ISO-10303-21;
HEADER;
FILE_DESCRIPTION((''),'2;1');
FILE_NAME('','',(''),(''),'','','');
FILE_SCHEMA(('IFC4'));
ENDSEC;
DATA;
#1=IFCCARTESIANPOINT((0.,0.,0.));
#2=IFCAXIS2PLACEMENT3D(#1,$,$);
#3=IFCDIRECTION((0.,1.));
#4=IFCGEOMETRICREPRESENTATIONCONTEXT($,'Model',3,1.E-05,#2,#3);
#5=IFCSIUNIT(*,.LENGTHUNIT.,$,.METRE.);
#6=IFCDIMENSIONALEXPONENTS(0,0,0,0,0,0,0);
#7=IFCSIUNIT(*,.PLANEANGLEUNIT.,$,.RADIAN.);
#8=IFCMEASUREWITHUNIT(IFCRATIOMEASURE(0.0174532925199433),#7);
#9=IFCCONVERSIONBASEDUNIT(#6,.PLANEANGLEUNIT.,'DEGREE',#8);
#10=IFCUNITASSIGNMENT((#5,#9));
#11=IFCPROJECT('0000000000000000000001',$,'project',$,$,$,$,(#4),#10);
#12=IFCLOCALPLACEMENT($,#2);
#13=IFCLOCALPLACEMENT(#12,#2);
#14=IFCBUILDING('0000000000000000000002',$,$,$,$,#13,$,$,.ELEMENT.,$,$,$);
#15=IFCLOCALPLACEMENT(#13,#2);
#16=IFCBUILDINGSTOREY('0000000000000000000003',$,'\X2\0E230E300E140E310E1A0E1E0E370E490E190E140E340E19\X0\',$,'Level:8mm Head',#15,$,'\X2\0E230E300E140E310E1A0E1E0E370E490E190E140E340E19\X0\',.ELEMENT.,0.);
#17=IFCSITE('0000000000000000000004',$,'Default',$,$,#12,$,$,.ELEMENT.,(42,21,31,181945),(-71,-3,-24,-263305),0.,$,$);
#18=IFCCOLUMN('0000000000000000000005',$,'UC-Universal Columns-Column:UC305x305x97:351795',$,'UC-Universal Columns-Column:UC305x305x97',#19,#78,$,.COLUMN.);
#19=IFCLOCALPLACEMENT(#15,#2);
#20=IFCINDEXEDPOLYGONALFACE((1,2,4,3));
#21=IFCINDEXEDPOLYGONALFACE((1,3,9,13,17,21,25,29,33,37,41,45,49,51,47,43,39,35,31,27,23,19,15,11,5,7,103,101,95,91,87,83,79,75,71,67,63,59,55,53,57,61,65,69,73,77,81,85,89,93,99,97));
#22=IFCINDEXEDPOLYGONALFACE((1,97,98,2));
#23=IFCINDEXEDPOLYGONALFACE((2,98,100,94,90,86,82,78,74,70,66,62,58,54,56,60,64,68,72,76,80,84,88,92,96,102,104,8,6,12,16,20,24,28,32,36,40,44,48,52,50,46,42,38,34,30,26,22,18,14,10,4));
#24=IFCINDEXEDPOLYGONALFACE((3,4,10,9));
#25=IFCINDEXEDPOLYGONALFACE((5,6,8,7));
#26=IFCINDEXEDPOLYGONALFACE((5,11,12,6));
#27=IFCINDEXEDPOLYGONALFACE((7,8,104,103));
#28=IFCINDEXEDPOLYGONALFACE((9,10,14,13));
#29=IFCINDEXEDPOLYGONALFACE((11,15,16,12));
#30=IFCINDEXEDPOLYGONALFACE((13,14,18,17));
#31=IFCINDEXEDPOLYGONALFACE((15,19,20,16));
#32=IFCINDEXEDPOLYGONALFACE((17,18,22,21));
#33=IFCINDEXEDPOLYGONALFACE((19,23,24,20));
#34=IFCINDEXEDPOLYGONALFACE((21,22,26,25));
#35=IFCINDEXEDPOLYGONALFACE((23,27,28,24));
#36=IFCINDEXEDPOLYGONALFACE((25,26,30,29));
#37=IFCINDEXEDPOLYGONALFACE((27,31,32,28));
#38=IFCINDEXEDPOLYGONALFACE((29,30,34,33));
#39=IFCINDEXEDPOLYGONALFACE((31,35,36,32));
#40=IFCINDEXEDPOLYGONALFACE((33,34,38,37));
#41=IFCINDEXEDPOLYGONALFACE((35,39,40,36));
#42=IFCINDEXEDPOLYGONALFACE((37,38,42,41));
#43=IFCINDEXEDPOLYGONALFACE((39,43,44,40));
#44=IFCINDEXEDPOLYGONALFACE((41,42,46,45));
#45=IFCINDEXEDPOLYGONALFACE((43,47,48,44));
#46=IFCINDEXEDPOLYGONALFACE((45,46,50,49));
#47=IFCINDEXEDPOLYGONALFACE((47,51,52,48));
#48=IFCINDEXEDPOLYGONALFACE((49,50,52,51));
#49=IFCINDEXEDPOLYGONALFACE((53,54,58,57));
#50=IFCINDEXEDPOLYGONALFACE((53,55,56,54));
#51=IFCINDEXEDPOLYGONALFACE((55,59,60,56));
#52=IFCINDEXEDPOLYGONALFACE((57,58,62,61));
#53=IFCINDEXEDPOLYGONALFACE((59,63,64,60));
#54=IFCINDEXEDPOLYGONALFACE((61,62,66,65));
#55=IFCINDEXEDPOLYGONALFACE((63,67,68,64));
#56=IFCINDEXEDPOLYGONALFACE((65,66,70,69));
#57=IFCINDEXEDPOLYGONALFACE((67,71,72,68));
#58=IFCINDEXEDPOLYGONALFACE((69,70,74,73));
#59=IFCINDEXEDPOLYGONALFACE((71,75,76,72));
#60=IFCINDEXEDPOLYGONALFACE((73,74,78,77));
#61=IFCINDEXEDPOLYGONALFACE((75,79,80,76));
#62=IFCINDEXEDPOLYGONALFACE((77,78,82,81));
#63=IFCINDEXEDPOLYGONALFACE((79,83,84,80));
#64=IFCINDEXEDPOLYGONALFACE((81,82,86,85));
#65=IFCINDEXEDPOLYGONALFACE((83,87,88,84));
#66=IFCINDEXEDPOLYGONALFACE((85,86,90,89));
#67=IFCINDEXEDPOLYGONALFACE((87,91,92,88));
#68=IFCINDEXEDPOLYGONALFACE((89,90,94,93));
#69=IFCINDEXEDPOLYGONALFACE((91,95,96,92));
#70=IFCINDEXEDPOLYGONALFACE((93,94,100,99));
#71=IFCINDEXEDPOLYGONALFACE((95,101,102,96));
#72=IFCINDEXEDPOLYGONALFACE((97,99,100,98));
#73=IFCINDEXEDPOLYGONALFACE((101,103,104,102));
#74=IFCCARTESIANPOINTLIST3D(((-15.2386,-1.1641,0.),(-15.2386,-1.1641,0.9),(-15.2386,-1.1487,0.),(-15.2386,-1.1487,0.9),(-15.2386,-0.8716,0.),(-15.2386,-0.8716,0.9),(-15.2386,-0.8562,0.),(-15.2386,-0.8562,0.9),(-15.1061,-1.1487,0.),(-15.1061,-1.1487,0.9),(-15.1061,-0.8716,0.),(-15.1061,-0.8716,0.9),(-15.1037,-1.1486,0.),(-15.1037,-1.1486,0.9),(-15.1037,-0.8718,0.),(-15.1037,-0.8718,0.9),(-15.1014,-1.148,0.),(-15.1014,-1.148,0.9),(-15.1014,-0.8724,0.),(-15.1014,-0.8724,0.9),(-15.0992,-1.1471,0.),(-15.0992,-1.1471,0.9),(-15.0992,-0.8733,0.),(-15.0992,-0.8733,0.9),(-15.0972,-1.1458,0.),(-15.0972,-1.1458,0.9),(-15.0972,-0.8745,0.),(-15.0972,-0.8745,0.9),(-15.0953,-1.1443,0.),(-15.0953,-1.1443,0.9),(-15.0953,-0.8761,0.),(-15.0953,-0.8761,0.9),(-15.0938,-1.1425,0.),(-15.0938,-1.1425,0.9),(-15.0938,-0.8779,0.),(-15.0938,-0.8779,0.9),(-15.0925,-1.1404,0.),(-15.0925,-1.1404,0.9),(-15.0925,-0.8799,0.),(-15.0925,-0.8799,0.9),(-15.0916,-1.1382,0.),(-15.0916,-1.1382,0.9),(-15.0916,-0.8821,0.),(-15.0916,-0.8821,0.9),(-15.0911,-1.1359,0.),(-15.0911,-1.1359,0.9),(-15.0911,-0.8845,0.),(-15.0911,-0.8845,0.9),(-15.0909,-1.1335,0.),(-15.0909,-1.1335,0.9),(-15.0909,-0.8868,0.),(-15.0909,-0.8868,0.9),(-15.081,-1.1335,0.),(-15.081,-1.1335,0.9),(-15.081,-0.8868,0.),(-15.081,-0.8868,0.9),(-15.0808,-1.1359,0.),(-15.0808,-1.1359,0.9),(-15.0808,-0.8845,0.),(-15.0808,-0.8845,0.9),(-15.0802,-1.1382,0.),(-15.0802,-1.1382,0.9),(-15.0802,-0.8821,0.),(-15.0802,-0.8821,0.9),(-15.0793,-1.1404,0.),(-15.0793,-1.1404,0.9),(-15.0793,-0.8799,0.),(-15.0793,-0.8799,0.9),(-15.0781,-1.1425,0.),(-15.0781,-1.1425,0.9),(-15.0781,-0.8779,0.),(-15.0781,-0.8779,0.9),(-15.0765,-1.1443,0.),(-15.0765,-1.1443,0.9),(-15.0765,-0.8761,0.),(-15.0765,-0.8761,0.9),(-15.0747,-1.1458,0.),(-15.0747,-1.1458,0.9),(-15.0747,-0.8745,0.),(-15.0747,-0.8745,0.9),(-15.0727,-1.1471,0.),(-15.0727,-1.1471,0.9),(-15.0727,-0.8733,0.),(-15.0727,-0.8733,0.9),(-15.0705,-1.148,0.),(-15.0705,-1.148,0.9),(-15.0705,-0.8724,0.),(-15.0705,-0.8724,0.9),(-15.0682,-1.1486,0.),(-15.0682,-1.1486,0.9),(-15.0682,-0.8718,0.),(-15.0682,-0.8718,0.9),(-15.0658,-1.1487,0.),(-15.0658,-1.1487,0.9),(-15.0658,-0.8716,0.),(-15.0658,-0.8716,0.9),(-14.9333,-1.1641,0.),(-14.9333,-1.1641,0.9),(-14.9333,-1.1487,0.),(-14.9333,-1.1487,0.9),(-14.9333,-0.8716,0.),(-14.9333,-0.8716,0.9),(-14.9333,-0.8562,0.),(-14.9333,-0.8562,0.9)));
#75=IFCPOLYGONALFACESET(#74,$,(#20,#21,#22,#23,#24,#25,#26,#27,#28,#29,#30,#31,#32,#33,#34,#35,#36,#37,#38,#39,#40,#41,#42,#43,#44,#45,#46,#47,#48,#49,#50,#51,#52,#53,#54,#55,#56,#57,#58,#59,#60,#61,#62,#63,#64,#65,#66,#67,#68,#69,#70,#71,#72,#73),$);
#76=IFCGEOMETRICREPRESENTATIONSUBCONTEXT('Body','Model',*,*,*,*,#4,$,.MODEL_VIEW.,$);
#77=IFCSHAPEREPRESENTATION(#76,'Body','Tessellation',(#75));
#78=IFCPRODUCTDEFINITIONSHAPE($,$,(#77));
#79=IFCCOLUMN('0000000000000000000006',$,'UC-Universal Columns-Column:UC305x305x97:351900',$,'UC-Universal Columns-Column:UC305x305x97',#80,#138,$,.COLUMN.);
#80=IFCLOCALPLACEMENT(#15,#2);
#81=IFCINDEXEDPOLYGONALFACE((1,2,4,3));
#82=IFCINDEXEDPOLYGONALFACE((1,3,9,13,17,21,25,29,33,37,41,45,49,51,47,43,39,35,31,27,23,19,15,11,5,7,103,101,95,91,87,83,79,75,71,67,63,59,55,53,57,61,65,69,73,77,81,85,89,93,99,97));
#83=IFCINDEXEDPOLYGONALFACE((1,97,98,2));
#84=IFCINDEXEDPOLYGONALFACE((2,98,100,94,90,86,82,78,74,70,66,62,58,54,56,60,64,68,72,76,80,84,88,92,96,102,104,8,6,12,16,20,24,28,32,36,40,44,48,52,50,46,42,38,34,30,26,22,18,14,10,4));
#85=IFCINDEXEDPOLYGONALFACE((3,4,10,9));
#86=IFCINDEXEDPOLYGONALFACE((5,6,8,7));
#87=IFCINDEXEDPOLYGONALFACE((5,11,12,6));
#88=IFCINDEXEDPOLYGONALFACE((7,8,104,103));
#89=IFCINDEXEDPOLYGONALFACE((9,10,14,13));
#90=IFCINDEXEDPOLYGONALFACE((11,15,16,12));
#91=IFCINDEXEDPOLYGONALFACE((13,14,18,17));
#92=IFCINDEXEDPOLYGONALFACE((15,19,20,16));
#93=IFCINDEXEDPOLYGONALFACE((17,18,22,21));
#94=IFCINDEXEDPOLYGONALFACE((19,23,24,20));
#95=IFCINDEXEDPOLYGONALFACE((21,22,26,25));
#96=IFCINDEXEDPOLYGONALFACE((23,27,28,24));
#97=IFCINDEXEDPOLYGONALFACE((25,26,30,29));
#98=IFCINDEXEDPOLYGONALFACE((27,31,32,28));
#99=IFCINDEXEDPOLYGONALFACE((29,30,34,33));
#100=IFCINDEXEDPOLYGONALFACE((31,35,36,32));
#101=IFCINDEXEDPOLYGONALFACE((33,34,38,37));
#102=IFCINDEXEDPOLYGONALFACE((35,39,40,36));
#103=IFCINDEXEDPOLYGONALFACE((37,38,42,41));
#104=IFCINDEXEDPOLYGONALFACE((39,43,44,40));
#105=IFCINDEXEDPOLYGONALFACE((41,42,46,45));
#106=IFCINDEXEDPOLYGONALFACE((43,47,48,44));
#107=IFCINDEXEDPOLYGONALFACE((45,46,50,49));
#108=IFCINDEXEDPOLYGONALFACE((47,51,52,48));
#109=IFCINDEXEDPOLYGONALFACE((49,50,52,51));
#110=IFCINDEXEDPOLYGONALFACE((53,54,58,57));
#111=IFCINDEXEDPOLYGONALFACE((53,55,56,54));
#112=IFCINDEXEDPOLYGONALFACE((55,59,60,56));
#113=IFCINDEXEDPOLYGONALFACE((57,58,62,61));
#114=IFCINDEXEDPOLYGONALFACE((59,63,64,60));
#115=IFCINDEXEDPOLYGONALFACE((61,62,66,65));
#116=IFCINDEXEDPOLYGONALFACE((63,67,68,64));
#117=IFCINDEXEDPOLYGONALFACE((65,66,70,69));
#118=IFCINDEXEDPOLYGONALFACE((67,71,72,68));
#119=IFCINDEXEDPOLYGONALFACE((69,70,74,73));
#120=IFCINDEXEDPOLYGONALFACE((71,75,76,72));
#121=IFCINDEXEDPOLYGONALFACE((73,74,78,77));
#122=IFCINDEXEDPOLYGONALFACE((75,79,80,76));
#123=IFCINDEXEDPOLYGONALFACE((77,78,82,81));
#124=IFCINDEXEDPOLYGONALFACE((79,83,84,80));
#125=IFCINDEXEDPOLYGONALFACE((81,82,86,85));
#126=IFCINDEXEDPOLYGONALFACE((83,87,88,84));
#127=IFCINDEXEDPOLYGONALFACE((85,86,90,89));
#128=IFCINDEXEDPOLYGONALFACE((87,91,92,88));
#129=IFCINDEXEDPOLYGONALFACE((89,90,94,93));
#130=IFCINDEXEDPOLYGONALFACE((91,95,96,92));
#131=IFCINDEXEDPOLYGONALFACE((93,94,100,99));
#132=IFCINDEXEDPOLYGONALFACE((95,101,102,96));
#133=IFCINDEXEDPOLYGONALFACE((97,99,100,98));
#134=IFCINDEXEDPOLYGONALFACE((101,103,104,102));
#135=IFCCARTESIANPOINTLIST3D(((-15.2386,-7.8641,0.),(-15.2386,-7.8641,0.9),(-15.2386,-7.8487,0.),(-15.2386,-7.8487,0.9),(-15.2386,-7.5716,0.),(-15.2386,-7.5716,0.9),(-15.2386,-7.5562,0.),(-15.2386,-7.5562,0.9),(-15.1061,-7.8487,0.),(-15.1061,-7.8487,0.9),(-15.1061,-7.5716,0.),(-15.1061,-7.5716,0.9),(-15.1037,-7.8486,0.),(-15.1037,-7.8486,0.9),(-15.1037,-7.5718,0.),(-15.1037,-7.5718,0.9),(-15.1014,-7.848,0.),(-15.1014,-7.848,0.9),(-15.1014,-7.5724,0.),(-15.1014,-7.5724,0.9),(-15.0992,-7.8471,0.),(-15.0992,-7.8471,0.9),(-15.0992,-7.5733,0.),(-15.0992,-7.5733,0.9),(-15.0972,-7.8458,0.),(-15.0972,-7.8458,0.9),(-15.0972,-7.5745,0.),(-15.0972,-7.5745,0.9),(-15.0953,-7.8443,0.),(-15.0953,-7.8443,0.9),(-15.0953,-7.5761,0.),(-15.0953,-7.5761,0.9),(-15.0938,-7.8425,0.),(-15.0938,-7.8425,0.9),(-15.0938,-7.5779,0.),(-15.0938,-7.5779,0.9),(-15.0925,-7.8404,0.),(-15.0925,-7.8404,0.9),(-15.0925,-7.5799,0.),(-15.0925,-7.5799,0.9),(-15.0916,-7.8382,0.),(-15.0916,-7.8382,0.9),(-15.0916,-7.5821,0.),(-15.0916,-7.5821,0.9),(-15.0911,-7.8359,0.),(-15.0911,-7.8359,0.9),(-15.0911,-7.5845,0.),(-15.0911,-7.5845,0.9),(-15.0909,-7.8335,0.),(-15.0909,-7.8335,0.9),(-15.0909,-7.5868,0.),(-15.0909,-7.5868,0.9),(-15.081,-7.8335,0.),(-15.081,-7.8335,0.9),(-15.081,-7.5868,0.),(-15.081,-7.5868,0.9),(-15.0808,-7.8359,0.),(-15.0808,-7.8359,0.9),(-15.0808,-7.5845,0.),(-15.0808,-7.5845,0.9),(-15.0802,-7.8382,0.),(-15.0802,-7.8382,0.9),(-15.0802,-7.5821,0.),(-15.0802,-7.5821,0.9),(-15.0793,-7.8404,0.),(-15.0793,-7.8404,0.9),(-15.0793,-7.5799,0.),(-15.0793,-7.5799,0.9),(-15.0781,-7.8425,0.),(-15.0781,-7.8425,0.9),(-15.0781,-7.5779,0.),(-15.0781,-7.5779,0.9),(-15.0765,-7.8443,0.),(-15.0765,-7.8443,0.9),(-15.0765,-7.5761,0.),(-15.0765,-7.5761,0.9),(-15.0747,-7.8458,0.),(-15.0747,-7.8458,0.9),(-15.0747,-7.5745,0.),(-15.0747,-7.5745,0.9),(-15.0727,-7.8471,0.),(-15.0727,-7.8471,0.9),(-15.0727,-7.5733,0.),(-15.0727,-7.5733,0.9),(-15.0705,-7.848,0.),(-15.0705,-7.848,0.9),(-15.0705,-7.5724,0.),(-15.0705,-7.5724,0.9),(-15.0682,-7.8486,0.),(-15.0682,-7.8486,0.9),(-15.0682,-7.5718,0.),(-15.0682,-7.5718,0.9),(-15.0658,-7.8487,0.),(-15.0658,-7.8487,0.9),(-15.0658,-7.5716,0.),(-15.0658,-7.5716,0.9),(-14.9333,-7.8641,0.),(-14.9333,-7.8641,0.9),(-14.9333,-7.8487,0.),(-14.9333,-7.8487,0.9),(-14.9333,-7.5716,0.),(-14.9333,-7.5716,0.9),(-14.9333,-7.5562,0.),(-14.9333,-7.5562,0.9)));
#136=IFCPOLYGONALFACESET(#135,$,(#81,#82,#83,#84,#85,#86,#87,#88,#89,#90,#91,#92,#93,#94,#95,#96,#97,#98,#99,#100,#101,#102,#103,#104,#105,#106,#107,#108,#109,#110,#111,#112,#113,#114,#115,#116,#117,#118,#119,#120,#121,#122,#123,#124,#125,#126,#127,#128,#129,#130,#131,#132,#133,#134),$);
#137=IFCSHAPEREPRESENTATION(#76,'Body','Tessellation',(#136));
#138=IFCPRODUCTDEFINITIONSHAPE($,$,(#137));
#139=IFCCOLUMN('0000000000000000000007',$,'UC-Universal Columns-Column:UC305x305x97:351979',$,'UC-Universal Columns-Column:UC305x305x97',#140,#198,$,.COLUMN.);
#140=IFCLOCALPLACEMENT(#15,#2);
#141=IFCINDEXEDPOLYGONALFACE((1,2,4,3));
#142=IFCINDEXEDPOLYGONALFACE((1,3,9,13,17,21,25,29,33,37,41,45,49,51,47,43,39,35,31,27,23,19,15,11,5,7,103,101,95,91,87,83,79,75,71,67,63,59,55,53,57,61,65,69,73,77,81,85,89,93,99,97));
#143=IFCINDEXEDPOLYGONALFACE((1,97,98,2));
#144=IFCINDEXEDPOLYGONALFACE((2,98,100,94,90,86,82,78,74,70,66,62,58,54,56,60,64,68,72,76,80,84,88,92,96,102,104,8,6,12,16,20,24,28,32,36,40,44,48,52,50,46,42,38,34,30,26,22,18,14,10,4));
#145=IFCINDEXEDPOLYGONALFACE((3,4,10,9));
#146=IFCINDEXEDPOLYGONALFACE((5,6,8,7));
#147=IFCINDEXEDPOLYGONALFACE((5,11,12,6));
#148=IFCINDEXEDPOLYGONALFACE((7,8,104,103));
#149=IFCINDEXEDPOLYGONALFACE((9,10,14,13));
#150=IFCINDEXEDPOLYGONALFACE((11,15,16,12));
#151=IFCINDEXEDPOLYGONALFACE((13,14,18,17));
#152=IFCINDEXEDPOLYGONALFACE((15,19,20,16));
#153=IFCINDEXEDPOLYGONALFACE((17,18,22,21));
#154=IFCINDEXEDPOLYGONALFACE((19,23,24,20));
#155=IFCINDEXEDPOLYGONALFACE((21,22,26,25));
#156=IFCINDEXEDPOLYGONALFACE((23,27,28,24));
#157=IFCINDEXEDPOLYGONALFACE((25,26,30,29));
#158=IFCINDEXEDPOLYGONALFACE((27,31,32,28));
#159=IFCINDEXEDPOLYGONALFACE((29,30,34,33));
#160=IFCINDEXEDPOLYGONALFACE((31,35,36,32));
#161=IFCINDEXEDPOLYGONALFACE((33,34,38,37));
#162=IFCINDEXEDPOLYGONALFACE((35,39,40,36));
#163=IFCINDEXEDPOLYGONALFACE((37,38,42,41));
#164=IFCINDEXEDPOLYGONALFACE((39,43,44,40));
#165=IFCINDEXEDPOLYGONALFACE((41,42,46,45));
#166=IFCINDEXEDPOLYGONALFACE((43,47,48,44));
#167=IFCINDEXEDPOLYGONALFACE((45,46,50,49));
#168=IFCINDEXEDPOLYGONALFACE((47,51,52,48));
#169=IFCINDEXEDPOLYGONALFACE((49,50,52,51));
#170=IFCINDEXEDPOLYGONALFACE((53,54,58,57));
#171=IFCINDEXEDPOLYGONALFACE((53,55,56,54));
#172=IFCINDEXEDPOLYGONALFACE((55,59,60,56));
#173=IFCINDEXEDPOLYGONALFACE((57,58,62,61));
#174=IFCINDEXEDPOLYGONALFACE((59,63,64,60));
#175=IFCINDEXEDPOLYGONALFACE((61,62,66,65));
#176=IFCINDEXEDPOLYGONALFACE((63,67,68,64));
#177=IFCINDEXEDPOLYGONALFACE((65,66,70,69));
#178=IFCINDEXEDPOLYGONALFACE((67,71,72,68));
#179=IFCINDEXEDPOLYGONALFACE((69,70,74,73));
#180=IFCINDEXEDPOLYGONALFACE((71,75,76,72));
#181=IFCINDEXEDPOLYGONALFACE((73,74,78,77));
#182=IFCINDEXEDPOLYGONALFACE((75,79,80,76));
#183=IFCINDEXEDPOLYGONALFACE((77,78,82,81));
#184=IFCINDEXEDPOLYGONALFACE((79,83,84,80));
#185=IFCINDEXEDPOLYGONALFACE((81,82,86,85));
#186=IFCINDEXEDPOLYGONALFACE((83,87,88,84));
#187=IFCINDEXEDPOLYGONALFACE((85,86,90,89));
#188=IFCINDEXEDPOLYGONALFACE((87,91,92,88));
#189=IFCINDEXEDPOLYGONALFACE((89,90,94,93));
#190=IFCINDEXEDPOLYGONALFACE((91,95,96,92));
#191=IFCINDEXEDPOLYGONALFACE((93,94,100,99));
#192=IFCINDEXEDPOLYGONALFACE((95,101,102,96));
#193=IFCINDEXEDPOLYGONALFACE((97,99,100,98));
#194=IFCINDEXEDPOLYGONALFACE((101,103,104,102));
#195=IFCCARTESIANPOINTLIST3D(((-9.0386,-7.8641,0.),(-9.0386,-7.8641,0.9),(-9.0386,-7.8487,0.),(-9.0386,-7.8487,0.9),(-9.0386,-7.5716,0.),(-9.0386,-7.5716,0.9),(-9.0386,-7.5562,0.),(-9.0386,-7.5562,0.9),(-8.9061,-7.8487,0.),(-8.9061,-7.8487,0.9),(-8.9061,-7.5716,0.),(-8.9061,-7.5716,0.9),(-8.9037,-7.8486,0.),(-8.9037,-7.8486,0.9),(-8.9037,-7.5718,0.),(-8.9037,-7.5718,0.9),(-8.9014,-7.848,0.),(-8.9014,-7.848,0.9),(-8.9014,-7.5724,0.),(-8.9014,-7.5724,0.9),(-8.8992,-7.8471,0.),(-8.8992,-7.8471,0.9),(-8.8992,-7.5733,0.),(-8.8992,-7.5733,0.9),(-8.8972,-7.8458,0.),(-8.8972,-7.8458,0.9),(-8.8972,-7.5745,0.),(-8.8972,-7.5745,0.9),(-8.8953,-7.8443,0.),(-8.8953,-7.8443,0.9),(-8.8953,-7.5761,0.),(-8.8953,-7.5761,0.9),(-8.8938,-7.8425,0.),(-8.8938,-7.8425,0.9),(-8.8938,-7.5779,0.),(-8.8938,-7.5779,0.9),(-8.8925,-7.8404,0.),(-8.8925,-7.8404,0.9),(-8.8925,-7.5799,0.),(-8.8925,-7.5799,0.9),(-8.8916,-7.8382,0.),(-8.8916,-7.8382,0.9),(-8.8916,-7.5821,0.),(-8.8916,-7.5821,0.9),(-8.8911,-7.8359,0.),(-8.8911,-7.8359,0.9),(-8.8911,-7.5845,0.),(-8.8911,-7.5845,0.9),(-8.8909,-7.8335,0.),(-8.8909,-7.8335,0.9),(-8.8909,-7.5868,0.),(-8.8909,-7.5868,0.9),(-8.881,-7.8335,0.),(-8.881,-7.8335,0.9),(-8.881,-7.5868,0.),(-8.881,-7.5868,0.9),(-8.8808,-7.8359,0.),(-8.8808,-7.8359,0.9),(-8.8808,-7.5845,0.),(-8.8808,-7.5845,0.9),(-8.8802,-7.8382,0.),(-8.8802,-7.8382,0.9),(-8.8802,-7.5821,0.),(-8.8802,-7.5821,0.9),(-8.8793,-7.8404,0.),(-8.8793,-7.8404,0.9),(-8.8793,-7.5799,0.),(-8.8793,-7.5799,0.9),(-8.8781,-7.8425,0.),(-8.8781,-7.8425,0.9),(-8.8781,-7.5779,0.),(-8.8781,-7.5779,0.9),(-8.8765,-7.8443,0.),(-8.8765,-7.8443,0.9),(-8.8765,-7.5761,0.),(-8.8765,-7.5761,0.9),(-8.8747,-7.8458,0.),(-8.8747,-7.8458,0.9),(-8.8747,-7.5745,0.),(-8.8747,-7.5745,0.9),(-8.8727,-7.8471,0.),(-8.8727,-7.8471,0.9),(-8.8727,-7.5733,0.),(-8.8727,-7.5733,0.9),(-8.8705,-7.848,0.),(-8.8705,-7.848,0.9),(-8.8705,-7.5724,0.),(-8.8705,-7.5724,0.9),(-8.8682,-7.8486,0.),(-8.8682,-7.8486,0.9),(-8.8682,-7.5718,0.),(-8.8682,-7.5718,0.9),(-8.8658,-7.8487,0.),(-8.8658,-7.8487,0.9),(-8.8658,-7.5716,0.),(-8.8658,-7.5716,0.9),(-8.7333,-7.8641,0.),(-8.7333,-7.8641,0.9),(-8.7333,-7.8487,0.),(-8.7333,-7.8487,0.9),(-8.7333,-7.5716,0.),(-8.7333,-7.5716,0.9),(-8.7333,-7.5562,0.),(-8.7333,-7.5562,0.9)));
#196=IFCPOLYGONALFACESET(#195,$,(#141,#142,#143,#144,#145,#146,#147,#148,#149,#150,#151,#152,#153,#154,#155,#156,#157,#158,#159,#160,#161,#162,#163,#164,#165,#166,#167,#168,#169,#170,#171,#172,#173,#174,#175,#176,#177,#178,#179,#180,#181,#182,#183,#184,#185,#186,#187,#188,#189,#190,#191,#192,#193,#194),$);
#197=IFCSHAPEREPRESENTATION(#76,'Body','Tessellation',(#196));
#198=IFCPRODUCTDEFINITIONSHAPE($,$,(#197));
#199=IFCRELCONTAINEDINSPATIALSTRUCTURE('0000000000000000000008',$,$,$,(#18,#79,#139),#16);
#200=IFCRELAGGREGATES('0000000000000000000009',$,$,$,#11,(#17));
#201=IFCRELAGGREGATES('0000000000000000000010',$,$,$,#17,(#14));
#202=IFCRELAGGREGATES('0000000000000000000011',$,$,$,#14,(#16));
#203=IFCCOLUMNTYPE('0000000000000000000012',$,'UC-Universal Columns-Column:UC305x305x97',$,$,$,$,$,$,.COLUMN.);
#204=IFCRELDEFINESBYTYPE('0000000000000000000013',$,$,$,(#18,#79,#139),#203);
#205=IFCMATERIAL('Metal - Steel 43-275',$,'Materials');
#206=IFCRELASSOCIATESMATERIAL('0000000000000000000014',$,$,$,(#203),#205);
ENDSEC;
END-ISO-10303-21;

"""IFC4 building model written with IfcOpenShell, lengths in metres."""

from ifc_helpers import new_model, entity, si_unit, converted_unit, direction, frame, origin, place, context, subcontext, project, spatial, indexed_curve, outline, extrude, source, transform, mapped, material, type_object, type_shapes, element, save


model = new_model("IFC4")

# Units and contexts
model_context = context("Model", 3, precision=1e-05, world=origin(), true_north=direction((0.0, 1.0)))
body_context = subcontext(model_context, "Body", "Model", "MODEL_VIEW")
ifc_project = project(units=[si_unit("LENGTHUNIT", "METRE"), converted_unit("PLANEANGLEUNIT", "DEGREE", entity("IfcRatioMeasure", 0.0174532925199433), si_unit("PLANEANGLEUNIT", "RADIAN"), dimensions=[0, 0, 0, 0, 0, 0, 0])], contexts=[model_context])

# Site, building, storey
site_placement = place(None, origin())
site = spatial("IfcSite", under=ifc_project, at=site_placement, Name="Default", CompositionType="ELEMENT", RefLatitude=(42, 21, 31, 181945), RefLongitude=(-71, -3, -24, -263305), RefElevation=0.0)
building_placement = place(site_placement, origin())
building = spatial("IfcBuilding", under=site, at=building_placement, CompositionType="ELEMENT")
storey_placement = place(building_placement, origin())
storey = spatial("IfcBuildingStorey", under=building, at=storey_placement, Name="ระดับพื้นดิน", ObjectType="Level:8mm Head", LongName="ระดับพื้นดิน", CompositionType="ELEMENT", Elevation=0.0)

# Columns
ifc_material_1 = material(Name="Metal - Steel 43-275", Category="Materials")
column_type_1 = type_object("IfcColumnType", Name="UC-Universal Columns-Column:UC305x305x97", PredefinedType="COLUMN", material=ifc_material_1)
shared_shape_1 = source(origin(), body_context, "Body", "SweptSolid", [
    extrude(outline(indexed_curve([(-0.154, -0.1527), (-0.1386, -0.1527), (-0.1386, -0.0202), (-0.1384, -0.0178), (-0.1378, -0.0155), (-0.1369, -0.0132), (-0.1356, -0.0112), (-0.1341, -0.0094), (-0.1323, -0.0079), (-0.1303, -0.0066), (-0.128, -0.0057), (-0.1257, -0.0051), (-0.1234, -0.0049), (0.1234, -0.0049), (0.1257, -0.0051), (0.128, -0.0057), (0.1303, -0.0066), (0.1323, -0.0079), (0.1341, -0.0094), (0.1356, -0.0112), (0.1369, -0.0132), (0.1378, -0.0155), (0.1384, -0.0178), (0.1386, -0.0201), (0.1386, -0.1527), (0.154, -0.1527), (0.154, 0.1527), (0.1386, 0.1527), (0.1386, 0.0202), (0.1384, 0.0178), (0.1378, 0.0155), (0.1369, 0.0132), (0.1356, 0.0112), (0.1341, 0.0094), (0.1323, 0.0079), (0.1303, 0.0066), (0.128, 0.0057), (0.1257, 0.0051), (0.1234, 0.005), (-0.1234, 0.005), (-0.1257, 0.0051), (-0.128, 0.0057), (-0.1303, 0.0066), (-0.1323, 0.0079), (-0.1341, 0.0094), (-0.1356, 0.0112), (-0.1369, 0.0132), (-0.1378, 0.0155), (-0.1384, 0.0178), (-0.1386, 0.0202), (-0.1386, 0.1527), (-0.154, 0.1527), (-0.154, -0.1527)], self_intersect=False)), frame((0.0, 0.0, 0.0), z_axis=(0.0, 0.0, 1.0), x_axis=(0.0, -1.0, 0.0)), (0.0, 0.0, 1.0), 0.9),
])
type_shapes(column_type_1, [shared_shape_1])
for number, where, name in (
    (1, (-15.0859, -1.0102, 0.0), "UC-Universal Columns-Column:UC305x305x97:351795"),
    (2, (-15.0859, -7.7102, 0.0), "UC-Universal Columns-Column:UC305x305x97:351900"),
    (3, (-8.8859, -7.7102, 0.0), "UC-Universal Columns-Column:UC305x305x97:351979"),
):
    element("IfcColumn", number, at=place(storey_placement, frame(where)), inside=storey, type_object=column_type_1, Name=name, ObjectType="UC-Universal Columns-Column:UC305x305x97", PredefinedType="COLUMN", context=body_context, shape_type="MappedRepresentation", body=[
        mapped(shared_shape_1, transform((0.0, 0.0, 0.0), scale=1.0)),
    ])

save(model, "model.ifc")
